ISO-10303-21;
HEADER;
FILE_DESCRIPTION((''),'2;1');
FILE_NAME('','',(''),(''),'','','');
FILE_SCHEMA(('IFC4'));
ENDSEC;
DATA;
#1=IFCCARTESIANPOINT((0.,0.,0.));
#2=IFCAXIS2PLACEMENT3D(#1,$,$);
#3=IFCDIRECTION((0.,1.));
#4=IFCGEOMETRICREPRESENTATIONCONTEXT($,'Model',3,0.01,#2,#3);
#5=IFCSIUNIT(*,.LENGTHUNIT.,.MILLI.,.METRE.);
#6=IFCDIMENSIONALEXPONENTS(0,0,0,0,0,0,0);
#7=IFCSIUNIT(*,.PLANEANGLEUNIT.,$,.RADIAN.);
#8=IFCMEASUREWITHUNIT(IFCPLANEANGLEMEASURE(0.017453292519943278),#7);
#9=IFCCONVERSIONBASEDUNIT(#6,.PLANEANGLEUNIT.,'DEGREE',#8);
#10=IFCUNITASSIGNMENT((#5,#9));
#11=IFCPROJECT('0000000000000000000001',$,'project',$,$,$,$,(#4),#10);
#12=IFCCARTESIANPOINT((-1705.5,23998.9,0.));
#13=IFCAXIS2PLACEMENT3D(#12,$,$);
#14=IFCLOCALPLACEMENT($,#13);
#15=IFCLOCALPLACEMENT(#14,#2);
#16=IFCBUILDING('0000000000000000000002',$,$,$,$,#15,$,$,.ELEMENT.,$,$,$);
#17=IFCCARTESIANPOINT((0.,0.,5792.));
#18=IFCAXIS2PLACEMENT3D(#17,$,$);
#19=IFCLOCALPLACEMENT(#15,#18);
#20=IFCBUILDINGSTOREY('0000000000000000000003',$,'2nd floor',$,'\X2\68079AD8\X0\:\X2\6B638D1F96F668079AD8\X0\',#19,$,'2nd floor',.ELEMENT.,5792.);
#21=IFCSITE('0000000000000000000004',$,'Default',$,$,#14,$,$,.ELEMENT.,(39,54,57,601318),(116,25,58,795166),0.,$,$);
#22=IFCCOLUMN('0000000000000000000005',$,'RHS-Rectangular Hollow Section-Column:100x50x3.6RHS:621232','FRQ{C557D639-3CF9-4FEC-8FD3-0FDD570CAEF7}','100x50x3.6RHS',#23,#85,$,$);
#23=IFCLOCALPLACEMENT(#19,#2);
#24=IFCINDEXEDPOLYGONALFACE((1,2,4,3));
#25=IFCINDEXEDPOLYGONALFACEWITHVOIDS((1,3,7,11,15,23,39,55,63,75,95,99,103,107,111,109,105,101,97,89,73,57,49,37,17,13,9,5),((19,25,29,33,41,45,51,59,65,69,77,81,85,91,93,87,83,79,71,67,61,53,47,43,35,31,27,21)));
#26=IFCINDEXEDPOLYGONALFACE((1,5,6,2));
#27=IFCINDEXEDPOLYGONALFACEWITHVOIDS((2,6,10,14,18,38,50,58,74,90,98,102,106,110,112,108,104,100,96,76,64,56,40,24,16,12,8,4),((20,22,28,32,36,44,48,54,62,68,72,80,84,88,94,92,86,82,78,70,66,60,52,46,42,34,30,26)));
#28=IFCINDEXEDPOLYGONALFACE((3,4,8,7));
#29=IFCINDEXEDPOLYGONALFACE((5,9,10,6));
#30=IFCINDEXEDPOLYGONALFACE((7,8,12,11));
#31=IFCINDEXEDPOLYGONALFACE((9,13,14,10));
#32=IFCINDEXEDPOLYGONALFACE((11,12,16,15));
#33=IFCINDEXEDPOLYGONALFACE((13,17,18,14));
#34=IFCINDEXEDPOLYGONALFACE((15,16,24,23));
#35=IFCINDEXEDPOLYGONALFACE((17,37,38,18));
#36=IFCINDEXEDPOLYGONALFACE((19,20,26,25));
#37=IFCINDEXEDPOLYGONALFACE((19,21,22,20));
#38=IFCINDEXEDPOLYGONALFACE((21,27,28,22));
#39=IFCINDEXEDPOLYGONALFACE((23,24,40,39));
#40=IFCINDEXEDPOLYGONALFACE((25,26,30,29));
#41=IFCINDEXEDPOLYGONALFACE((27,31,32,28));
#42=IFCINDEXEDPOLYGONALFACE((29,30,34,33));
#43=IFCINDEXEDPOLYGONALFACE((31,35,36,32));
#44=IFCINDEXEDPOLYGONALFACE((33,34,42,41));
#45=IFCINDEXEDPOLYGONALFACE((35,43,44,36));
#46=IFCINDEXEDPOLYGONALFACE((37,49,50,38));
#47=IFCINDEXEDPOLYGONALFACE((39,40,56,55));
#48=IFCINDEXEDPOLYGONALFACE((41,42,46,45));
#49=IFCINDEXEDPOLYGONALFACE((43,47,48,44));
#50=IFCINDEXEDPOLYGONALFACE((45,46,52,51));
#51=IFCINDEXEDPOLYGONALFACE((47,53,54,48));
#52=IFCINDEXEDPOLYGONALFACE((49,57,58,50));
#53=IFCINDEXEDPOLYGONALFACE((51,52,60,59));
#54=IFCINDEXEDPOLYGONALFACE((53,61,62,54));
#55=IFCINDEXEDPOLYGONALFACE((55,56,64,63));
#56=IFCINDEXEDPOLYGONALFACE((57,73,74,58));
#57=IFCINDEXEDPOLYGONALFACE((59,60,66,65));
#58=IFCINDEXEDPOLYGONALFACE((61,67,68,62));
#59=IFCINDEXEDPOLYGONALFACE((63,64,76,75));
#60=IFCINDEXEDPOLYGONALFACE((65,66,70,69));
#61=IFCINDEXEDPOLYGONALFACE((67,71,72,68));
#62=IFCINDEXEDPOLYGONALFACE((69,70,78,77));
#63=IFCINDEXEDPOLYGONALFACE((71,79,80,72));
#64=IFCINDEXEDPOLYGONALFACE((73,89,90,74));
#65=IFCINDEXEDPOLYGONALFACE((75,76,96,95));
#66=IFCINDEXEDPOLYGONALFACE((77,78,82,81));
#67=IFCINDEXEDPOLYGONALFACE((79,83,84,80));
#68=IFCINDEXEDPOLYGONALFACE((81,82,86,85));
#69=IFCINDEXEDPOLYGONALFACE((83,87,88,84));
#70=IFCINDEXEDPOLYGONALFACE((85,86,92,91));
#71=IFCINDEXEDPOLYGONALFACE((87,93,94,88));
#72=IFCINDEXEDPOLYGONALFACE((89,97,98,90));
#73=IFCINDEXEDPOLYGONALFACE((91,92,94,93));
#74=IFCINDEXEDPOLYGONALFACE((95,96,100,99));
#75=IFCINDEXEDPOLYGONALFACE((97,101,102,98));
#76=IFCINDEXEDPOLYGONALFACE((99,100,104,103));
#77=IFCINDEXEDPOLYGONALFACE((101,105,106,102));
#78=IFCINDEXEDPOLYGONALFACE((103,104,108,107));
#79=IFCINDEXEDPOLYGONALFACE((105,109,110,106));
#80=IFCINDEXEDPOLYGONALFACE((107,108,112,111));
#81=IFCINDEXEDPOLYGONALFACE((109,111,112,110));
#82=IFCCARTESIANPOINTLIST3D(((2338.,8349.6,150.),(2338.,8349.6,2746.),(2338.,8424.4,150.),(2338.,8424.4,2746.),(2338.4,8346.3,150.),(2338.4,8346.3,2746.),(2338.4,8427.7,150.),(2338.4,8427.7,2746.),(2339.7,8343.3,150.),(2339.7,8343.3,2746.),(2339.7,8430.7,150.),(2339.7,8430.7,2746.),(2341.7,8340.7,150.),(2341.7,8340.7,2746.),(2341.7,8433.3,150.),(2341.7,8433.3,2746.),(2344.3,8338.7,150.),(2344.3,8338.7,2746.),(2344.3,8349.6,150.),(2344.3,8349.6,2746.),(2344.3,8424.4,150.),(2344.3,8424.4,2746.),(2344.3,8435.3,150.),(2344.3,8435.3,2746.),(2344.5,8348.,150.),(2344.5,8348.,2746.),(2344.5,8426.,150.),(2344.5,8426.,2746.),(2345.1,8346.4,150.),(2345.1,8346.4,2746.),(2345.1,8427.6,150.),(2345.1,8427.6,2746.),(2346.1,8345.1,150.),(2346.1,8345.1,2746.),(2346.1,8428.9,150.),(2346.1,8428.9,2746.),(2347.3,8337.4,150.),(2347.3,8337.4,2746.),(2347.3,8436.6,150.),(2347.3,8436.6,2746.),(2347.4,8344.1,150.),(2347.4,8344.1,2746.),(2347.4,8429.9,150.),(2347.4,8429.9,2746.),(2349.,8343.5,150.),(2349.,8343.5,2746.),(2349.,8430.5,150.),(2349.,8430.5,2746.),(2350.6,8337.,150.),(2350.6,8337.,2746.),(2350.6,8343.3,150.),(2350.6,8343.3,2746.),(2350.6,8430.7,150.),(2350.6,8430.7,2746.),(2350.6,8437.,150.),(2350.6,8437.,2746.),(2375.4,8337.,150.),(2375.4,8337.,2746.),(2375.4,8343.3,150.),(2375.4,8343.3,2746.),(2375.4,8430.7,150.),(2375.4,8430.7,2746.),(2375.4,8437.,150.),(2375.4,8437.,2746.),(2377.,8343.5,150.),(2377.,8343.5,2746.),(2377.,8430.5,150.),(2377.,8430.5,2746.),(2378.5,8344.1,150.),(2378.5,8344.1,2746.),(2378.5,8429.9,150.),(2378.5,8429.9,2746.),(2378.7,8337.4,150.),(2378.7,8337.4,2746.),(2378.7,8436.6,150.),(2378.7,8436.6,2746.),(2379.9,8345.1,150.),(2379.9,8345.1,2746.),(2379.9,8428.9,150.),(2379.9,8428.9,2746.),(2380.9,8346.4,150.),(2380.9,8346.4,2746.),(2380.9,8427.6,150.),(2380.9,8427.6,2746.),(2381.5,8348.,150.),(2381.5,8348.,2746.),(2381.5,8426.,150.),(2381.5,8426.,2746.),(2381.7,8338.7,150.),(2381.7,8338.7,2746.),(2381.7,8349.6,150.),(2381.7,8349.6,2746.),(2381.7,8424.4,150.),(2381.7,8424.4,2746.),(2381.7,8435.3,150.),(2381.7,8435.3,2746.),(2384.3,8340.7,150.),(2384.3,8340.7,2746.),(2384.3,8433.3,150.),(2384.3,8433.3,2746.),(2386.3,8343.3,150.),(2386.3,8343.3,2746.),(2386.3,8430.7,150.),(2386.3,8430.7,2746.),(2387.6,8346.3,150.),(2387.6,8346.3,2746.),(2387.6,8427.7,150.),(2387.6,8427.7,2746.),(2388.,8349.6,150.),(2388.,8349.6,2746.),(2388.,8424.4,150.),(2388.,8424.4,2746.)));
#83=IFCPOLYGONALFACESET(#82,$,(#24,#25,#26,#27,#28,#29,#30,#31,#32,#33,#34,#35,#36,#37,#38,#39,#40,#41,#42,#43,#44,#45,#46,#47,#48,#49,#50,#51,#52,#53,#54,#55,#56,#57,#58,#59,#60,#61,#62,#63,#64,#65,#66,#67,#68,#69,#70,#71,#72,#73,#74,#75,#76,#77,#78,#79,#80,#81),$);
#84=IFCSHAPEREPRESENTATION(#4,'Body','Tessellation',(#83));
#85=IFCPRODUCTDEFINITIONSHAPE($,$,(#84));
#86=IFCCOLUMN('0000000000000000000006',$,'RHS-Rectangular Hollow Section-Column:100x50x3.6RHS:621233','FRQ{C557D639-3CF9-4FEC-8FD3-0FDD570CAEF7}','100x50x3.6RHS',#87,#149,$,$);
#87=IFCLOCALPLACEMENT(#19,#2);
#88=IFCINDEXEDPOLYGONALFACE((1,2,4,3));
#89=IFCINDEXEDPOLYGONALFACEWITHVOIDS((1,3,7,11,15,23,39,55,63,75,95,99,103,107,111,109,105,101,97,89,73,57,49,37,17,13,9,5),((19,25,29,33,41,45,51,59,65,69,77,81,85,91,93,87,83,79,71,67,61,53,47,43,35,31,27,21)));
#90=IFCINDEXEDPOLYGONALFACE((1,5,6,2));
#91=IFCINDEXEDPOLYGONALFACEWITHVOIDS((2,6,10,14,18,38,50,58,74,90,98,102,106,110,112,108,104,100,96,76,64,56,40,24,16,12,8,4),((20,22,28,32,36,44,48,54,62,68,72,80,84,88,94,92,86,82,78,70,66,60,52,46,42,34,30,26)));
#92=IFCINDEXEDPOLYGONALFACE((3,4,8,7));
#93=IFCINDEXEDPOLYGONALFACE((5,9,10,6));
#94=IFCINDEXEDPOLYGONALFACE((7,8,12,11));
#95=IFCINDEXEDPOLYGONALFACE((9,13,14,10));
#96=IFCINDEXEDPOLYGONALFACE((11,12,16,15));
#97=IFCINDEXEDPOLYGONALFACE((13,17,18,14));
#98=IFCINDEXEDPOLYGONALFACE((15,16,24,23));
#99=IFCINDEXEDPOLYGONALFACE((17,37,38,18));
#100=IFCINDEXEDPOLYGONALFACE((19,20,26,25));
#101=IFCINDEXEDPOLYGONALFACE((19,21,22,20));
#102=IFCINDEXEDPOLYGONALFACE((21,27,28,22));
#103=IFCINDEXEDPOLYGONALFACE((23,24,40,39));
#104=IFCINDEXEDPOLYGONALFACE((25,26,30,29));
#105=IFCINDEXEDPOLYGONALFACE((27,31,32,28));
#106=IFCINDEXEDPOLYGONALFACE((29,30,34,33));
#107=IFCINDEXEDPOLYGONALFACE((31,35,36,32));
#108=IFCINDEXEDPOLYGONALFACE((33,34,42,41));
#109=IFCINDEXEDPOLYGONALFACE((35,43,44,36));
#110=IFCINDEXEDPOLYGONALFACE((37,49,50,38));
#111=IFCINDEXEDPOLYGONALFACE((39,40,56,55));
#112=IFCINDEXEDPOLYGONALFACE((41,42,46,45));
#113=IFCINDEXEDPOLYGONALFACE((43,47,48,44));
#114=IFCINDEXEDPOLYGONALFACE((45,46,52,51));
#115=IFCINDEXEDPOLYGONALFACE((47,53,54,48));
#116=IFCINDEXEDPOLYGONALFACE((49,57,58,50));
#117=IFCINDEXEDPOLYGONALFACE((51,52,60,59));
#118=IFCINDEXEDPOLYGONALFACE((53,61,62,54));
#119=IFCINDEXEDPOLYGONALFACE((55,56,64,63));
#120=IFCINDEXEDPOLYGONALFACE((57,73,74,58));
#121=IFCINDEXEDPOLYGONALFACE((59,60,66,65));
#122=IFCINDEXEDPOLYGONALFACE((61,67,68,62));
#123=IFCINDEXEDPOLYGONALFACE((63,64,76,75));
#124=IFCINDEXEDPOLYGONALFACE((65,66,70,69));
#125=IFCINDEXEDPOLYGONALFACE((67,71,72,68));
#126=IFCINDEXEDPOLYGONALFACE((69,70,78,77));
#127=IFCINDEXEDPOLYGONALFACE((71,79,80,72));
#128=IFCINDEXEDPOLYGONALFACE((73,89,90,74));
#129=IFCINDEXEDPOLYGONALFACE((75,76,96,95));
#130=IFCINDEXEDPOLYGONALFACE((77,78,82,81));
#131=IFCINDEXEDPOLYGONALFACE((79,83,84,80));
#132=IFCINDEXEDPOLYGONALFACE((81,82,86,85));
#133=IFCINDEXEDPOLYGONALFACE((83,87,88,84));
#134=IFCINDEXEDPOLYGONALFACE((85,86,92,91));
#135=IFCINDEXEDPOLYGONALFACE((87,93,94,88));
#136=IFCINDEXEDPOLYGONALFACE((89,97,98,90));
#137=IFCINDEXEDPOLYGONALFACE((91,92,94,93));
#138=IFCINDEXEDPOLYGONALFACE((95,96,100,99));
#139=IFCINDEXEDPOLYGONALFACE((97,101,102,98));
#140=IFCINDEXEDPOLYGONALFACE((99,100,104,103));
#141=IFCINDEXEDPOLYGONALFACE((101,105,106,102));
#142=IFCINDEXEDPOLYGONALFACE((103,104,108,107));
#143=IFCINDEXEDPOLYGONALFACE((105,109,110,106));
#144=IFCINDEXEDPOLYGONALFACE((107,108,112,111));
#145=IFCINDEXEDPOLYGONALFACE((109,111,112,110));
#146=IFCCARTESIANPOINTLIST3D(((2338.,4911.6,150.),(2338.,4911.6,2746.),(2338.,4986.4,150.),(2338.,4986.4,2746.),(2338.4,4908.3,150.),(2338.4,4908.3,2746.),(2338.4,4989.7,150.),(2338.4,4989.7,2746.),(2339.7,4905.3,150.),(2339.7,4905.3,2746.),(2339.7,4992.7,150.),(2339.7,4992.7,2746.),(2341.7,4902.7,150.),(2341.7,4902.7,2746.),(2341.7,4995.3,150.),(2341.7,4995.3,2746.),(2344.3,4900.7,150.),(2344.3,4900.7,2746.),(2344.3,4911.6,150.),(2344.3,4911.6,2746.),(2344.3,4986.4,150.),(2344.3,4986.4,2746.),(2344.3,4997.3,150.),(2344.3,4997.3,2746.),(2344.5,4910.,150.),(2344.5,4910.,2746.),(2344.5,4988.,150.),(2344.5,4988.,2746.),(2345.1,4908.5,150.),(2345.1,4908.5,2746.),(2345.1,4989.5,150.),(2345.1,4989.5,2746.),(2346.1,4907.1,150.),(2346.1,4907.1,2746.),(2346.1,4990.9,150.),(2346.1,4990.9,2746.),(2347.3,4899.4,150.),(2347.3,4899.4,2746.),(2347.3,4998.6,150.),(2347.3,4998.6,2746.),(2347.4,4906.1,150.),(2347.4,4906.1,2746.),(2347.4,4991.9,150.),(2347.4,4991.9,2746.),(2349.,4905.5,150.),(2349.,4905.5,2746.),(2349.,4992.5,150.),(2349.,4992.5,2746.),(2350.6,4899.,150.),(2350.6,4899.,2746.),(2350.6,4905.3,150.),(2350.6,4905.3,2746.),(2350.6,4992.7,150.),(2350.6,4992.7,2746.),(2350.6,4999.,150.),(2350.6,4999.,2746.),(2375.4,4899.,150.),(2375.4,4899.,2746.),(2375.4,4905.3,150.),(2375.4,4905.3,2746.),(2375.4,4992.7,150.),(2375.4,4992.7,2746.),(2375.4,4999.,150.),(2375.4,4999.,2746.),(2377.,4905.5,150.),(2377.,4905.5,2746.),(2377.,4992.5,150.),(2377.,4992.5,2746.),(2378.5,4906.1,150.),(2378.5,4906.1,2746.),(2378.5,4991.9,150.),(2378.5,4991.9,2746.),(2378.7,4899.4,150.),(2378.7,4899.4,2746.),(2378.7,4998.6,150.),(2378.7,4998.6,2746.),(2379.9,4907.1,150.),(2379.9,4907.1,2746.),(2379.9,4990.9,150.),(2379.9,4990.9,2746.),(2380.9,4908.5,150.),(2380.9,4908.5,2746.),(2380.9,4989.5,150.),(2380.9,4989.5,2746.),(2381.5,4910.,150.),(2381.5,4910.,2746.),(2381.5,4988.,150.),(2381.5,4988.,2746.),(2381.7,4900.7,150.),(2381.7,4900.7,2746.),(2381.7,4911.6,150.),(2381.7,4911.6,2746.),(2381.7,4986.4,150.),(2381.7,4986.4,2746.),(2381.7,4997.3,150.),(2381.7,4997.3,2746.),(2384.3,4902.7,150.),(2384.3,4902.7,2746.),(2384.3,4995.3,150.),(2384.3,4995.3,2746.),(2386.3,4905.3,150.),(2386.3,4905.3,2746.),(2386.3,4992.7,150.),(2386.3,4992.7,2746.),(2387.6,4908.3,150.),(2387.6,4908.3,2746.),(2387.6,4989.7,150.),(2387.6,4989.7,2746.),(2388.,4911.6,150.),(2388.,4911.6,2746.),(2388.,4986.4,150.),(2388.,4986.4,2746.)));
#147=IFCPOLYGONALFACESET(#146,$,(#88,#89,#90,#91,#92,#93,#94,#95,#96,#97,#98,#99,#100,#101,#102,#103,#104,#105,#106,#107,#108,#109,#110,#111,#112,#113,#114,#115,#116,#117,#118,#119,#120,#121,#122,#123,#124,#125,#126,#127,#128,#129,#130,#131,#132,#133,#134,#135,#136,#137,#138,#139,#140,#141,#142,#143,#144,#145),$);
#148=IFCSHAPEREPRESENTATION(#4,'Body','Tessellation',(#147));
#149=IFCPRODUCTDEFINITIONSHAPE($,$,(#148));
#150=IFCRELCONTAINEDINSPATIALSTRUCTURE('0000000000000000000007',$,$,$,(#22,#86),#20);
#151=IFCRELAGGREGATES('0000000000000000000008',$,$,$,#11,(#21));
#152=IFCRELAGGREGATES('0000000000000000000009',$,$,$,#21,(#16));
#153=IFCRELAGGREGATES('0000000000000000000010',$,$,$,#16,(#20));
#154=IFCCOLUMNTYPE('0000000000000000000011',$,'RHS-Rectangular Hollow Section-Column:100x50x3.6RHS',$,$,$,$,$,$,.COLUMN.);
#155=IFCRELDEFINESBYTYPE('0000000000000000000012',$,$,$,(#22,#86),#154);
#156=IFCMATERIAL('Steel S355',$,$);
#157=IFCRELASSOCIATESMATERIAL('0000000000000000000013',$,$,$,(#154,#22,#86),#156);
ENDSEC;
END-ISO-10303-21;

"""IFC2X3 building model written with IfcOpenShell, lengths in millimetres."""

from ifc_helpers import new_model, entity, si_unit, converted_unit, direction, frame, origin, origin_2d, place, context, project, spatial, hollow_rectangle, extrude, clip, halfspace, material, type_object, element, save


model = new_model("IFC2X3")

# Units and contexts
model_context = context("Model", 3, precision=0.01, world=origin(), true_north=direction((0.0, 1.0)))
ifc_project = project(units=[si_unit("LENGTHUNIT", "METRE", prefix="MILLI"), converted_unit("PLANEANGLEUNIT", "DEGREE", entity("IfcPlaneAngleMeasure", 0.017453292519943278), si_unit("PLANEANGLEUNIT", "RADIAN"), dimensions=[0, 0, 0, 0, 0, 0, 0])], contexts=[model_context])

# Site, building, storey
site_placement = place(None, frame((-1705.5, 23998.9, 0.0)))
site = spatial("IfcSite", under=ifc_project, at=site_placement, Name="Default", CompositionType="ELEMENT", RefLatitude=(39, 54, 57, 601318), RefLongitude=(116, 25, 58, 795166), RefElevation=0.0)
building_placement = place(site_placement, origin())
building = spatial("IfcBuilding", under=site, at=building_placement, CompositionType="ELEMENT")
storey_placement = place(building_placement, frame((0.0, 0.0, 5792.0)))
storey = spatial("IfcBuildingStorey", under=building, at=storey_placement, Name="2nd floor", ObjectType="标高:正负零标高", LongName="2nd floor", CompositionType="ELEMENT", Elevation=5792.0)

# Columns
ifc_material_1 = material(Name="Steel S355")
column_type_1 = type_object("IfcColumnType", Name="RHS-Rectangular Hollow Section-Column:100x50x3.6RHS", PredefinedType="COLUMN", material=ifc_material_1)
column_1_placement = place(storey_placement, frame((2363.0, 8387.0, 2746.0), z_axis=(0.0, 0.0, 1.0), x_axis=(-1.0, 0.0, 0.0)))
element("IfcColumn", 1, at=column_1_placement, inside=storey, type_object=column_type_1, material=ifc_material_1, Name="RHS-Rectangular Hollow Section-Column:100x50x3.6RHS:621232", Description="FRQ{C557D639-3CF9-4FEC-8FD3-0FDD570CAEF7}", ObjectType="100x50x3.6RHS", context=model_context, shape_type="Clipping", body=[
    clip(extrude(hollow_rectangle(XDim=50.0, YDim=100.0, WallThickness=6.3, InnerFilletRadius=6.3, OuterFilletRadius=12.6, at=origin_2d()), origin(), (0.0, 0.0, -1.0), 2651.9), halfspace(frame((2363.0, 8387.0, -2596.0), z_axis=(0.0, 0.0, 1.0), x_axis=(-1.0, 0.0, 0.0)), True)),
])
column_2_placement = place(storey_placement, frame((2363.0, 4949.0, 2746.0), z_axis=(0.0, 0.0, 1.0), x_axis=(-1.0, 0.0, 0.0)))
element("IfcColumn", 2, at=column_2_placement, inside=storey, type_object=column_type_1, material=ifc_material_1, Name="RHS-Rectangular Hollow Section-Column:100x50x3.6RHS:621233", Description="FRQ{C557D639-3CF9-4FEC-8FD3-0FDD570CAEF7}", ObjectType="100x50x3.6RHS", context=model_context, shape_type="Clipping", body=[
    clip(extrude(hollow_rectangle(XDim=50.0, YDim=100.0, WallThickness=6.3, InnerFilletRadius=6.3, OuterFilletRadius=12.6, at=origin_2d()), origin(), (0.0, 0.0, -1.0), 2651.9), halfspace(frame((2363.0, 4949.0, -2596.0), z_axis=(0.0, 0.0, 1.0), x_axis=(-1.0, 0.0, 0.0)), True)),
])

save(model, "model.ifc")
